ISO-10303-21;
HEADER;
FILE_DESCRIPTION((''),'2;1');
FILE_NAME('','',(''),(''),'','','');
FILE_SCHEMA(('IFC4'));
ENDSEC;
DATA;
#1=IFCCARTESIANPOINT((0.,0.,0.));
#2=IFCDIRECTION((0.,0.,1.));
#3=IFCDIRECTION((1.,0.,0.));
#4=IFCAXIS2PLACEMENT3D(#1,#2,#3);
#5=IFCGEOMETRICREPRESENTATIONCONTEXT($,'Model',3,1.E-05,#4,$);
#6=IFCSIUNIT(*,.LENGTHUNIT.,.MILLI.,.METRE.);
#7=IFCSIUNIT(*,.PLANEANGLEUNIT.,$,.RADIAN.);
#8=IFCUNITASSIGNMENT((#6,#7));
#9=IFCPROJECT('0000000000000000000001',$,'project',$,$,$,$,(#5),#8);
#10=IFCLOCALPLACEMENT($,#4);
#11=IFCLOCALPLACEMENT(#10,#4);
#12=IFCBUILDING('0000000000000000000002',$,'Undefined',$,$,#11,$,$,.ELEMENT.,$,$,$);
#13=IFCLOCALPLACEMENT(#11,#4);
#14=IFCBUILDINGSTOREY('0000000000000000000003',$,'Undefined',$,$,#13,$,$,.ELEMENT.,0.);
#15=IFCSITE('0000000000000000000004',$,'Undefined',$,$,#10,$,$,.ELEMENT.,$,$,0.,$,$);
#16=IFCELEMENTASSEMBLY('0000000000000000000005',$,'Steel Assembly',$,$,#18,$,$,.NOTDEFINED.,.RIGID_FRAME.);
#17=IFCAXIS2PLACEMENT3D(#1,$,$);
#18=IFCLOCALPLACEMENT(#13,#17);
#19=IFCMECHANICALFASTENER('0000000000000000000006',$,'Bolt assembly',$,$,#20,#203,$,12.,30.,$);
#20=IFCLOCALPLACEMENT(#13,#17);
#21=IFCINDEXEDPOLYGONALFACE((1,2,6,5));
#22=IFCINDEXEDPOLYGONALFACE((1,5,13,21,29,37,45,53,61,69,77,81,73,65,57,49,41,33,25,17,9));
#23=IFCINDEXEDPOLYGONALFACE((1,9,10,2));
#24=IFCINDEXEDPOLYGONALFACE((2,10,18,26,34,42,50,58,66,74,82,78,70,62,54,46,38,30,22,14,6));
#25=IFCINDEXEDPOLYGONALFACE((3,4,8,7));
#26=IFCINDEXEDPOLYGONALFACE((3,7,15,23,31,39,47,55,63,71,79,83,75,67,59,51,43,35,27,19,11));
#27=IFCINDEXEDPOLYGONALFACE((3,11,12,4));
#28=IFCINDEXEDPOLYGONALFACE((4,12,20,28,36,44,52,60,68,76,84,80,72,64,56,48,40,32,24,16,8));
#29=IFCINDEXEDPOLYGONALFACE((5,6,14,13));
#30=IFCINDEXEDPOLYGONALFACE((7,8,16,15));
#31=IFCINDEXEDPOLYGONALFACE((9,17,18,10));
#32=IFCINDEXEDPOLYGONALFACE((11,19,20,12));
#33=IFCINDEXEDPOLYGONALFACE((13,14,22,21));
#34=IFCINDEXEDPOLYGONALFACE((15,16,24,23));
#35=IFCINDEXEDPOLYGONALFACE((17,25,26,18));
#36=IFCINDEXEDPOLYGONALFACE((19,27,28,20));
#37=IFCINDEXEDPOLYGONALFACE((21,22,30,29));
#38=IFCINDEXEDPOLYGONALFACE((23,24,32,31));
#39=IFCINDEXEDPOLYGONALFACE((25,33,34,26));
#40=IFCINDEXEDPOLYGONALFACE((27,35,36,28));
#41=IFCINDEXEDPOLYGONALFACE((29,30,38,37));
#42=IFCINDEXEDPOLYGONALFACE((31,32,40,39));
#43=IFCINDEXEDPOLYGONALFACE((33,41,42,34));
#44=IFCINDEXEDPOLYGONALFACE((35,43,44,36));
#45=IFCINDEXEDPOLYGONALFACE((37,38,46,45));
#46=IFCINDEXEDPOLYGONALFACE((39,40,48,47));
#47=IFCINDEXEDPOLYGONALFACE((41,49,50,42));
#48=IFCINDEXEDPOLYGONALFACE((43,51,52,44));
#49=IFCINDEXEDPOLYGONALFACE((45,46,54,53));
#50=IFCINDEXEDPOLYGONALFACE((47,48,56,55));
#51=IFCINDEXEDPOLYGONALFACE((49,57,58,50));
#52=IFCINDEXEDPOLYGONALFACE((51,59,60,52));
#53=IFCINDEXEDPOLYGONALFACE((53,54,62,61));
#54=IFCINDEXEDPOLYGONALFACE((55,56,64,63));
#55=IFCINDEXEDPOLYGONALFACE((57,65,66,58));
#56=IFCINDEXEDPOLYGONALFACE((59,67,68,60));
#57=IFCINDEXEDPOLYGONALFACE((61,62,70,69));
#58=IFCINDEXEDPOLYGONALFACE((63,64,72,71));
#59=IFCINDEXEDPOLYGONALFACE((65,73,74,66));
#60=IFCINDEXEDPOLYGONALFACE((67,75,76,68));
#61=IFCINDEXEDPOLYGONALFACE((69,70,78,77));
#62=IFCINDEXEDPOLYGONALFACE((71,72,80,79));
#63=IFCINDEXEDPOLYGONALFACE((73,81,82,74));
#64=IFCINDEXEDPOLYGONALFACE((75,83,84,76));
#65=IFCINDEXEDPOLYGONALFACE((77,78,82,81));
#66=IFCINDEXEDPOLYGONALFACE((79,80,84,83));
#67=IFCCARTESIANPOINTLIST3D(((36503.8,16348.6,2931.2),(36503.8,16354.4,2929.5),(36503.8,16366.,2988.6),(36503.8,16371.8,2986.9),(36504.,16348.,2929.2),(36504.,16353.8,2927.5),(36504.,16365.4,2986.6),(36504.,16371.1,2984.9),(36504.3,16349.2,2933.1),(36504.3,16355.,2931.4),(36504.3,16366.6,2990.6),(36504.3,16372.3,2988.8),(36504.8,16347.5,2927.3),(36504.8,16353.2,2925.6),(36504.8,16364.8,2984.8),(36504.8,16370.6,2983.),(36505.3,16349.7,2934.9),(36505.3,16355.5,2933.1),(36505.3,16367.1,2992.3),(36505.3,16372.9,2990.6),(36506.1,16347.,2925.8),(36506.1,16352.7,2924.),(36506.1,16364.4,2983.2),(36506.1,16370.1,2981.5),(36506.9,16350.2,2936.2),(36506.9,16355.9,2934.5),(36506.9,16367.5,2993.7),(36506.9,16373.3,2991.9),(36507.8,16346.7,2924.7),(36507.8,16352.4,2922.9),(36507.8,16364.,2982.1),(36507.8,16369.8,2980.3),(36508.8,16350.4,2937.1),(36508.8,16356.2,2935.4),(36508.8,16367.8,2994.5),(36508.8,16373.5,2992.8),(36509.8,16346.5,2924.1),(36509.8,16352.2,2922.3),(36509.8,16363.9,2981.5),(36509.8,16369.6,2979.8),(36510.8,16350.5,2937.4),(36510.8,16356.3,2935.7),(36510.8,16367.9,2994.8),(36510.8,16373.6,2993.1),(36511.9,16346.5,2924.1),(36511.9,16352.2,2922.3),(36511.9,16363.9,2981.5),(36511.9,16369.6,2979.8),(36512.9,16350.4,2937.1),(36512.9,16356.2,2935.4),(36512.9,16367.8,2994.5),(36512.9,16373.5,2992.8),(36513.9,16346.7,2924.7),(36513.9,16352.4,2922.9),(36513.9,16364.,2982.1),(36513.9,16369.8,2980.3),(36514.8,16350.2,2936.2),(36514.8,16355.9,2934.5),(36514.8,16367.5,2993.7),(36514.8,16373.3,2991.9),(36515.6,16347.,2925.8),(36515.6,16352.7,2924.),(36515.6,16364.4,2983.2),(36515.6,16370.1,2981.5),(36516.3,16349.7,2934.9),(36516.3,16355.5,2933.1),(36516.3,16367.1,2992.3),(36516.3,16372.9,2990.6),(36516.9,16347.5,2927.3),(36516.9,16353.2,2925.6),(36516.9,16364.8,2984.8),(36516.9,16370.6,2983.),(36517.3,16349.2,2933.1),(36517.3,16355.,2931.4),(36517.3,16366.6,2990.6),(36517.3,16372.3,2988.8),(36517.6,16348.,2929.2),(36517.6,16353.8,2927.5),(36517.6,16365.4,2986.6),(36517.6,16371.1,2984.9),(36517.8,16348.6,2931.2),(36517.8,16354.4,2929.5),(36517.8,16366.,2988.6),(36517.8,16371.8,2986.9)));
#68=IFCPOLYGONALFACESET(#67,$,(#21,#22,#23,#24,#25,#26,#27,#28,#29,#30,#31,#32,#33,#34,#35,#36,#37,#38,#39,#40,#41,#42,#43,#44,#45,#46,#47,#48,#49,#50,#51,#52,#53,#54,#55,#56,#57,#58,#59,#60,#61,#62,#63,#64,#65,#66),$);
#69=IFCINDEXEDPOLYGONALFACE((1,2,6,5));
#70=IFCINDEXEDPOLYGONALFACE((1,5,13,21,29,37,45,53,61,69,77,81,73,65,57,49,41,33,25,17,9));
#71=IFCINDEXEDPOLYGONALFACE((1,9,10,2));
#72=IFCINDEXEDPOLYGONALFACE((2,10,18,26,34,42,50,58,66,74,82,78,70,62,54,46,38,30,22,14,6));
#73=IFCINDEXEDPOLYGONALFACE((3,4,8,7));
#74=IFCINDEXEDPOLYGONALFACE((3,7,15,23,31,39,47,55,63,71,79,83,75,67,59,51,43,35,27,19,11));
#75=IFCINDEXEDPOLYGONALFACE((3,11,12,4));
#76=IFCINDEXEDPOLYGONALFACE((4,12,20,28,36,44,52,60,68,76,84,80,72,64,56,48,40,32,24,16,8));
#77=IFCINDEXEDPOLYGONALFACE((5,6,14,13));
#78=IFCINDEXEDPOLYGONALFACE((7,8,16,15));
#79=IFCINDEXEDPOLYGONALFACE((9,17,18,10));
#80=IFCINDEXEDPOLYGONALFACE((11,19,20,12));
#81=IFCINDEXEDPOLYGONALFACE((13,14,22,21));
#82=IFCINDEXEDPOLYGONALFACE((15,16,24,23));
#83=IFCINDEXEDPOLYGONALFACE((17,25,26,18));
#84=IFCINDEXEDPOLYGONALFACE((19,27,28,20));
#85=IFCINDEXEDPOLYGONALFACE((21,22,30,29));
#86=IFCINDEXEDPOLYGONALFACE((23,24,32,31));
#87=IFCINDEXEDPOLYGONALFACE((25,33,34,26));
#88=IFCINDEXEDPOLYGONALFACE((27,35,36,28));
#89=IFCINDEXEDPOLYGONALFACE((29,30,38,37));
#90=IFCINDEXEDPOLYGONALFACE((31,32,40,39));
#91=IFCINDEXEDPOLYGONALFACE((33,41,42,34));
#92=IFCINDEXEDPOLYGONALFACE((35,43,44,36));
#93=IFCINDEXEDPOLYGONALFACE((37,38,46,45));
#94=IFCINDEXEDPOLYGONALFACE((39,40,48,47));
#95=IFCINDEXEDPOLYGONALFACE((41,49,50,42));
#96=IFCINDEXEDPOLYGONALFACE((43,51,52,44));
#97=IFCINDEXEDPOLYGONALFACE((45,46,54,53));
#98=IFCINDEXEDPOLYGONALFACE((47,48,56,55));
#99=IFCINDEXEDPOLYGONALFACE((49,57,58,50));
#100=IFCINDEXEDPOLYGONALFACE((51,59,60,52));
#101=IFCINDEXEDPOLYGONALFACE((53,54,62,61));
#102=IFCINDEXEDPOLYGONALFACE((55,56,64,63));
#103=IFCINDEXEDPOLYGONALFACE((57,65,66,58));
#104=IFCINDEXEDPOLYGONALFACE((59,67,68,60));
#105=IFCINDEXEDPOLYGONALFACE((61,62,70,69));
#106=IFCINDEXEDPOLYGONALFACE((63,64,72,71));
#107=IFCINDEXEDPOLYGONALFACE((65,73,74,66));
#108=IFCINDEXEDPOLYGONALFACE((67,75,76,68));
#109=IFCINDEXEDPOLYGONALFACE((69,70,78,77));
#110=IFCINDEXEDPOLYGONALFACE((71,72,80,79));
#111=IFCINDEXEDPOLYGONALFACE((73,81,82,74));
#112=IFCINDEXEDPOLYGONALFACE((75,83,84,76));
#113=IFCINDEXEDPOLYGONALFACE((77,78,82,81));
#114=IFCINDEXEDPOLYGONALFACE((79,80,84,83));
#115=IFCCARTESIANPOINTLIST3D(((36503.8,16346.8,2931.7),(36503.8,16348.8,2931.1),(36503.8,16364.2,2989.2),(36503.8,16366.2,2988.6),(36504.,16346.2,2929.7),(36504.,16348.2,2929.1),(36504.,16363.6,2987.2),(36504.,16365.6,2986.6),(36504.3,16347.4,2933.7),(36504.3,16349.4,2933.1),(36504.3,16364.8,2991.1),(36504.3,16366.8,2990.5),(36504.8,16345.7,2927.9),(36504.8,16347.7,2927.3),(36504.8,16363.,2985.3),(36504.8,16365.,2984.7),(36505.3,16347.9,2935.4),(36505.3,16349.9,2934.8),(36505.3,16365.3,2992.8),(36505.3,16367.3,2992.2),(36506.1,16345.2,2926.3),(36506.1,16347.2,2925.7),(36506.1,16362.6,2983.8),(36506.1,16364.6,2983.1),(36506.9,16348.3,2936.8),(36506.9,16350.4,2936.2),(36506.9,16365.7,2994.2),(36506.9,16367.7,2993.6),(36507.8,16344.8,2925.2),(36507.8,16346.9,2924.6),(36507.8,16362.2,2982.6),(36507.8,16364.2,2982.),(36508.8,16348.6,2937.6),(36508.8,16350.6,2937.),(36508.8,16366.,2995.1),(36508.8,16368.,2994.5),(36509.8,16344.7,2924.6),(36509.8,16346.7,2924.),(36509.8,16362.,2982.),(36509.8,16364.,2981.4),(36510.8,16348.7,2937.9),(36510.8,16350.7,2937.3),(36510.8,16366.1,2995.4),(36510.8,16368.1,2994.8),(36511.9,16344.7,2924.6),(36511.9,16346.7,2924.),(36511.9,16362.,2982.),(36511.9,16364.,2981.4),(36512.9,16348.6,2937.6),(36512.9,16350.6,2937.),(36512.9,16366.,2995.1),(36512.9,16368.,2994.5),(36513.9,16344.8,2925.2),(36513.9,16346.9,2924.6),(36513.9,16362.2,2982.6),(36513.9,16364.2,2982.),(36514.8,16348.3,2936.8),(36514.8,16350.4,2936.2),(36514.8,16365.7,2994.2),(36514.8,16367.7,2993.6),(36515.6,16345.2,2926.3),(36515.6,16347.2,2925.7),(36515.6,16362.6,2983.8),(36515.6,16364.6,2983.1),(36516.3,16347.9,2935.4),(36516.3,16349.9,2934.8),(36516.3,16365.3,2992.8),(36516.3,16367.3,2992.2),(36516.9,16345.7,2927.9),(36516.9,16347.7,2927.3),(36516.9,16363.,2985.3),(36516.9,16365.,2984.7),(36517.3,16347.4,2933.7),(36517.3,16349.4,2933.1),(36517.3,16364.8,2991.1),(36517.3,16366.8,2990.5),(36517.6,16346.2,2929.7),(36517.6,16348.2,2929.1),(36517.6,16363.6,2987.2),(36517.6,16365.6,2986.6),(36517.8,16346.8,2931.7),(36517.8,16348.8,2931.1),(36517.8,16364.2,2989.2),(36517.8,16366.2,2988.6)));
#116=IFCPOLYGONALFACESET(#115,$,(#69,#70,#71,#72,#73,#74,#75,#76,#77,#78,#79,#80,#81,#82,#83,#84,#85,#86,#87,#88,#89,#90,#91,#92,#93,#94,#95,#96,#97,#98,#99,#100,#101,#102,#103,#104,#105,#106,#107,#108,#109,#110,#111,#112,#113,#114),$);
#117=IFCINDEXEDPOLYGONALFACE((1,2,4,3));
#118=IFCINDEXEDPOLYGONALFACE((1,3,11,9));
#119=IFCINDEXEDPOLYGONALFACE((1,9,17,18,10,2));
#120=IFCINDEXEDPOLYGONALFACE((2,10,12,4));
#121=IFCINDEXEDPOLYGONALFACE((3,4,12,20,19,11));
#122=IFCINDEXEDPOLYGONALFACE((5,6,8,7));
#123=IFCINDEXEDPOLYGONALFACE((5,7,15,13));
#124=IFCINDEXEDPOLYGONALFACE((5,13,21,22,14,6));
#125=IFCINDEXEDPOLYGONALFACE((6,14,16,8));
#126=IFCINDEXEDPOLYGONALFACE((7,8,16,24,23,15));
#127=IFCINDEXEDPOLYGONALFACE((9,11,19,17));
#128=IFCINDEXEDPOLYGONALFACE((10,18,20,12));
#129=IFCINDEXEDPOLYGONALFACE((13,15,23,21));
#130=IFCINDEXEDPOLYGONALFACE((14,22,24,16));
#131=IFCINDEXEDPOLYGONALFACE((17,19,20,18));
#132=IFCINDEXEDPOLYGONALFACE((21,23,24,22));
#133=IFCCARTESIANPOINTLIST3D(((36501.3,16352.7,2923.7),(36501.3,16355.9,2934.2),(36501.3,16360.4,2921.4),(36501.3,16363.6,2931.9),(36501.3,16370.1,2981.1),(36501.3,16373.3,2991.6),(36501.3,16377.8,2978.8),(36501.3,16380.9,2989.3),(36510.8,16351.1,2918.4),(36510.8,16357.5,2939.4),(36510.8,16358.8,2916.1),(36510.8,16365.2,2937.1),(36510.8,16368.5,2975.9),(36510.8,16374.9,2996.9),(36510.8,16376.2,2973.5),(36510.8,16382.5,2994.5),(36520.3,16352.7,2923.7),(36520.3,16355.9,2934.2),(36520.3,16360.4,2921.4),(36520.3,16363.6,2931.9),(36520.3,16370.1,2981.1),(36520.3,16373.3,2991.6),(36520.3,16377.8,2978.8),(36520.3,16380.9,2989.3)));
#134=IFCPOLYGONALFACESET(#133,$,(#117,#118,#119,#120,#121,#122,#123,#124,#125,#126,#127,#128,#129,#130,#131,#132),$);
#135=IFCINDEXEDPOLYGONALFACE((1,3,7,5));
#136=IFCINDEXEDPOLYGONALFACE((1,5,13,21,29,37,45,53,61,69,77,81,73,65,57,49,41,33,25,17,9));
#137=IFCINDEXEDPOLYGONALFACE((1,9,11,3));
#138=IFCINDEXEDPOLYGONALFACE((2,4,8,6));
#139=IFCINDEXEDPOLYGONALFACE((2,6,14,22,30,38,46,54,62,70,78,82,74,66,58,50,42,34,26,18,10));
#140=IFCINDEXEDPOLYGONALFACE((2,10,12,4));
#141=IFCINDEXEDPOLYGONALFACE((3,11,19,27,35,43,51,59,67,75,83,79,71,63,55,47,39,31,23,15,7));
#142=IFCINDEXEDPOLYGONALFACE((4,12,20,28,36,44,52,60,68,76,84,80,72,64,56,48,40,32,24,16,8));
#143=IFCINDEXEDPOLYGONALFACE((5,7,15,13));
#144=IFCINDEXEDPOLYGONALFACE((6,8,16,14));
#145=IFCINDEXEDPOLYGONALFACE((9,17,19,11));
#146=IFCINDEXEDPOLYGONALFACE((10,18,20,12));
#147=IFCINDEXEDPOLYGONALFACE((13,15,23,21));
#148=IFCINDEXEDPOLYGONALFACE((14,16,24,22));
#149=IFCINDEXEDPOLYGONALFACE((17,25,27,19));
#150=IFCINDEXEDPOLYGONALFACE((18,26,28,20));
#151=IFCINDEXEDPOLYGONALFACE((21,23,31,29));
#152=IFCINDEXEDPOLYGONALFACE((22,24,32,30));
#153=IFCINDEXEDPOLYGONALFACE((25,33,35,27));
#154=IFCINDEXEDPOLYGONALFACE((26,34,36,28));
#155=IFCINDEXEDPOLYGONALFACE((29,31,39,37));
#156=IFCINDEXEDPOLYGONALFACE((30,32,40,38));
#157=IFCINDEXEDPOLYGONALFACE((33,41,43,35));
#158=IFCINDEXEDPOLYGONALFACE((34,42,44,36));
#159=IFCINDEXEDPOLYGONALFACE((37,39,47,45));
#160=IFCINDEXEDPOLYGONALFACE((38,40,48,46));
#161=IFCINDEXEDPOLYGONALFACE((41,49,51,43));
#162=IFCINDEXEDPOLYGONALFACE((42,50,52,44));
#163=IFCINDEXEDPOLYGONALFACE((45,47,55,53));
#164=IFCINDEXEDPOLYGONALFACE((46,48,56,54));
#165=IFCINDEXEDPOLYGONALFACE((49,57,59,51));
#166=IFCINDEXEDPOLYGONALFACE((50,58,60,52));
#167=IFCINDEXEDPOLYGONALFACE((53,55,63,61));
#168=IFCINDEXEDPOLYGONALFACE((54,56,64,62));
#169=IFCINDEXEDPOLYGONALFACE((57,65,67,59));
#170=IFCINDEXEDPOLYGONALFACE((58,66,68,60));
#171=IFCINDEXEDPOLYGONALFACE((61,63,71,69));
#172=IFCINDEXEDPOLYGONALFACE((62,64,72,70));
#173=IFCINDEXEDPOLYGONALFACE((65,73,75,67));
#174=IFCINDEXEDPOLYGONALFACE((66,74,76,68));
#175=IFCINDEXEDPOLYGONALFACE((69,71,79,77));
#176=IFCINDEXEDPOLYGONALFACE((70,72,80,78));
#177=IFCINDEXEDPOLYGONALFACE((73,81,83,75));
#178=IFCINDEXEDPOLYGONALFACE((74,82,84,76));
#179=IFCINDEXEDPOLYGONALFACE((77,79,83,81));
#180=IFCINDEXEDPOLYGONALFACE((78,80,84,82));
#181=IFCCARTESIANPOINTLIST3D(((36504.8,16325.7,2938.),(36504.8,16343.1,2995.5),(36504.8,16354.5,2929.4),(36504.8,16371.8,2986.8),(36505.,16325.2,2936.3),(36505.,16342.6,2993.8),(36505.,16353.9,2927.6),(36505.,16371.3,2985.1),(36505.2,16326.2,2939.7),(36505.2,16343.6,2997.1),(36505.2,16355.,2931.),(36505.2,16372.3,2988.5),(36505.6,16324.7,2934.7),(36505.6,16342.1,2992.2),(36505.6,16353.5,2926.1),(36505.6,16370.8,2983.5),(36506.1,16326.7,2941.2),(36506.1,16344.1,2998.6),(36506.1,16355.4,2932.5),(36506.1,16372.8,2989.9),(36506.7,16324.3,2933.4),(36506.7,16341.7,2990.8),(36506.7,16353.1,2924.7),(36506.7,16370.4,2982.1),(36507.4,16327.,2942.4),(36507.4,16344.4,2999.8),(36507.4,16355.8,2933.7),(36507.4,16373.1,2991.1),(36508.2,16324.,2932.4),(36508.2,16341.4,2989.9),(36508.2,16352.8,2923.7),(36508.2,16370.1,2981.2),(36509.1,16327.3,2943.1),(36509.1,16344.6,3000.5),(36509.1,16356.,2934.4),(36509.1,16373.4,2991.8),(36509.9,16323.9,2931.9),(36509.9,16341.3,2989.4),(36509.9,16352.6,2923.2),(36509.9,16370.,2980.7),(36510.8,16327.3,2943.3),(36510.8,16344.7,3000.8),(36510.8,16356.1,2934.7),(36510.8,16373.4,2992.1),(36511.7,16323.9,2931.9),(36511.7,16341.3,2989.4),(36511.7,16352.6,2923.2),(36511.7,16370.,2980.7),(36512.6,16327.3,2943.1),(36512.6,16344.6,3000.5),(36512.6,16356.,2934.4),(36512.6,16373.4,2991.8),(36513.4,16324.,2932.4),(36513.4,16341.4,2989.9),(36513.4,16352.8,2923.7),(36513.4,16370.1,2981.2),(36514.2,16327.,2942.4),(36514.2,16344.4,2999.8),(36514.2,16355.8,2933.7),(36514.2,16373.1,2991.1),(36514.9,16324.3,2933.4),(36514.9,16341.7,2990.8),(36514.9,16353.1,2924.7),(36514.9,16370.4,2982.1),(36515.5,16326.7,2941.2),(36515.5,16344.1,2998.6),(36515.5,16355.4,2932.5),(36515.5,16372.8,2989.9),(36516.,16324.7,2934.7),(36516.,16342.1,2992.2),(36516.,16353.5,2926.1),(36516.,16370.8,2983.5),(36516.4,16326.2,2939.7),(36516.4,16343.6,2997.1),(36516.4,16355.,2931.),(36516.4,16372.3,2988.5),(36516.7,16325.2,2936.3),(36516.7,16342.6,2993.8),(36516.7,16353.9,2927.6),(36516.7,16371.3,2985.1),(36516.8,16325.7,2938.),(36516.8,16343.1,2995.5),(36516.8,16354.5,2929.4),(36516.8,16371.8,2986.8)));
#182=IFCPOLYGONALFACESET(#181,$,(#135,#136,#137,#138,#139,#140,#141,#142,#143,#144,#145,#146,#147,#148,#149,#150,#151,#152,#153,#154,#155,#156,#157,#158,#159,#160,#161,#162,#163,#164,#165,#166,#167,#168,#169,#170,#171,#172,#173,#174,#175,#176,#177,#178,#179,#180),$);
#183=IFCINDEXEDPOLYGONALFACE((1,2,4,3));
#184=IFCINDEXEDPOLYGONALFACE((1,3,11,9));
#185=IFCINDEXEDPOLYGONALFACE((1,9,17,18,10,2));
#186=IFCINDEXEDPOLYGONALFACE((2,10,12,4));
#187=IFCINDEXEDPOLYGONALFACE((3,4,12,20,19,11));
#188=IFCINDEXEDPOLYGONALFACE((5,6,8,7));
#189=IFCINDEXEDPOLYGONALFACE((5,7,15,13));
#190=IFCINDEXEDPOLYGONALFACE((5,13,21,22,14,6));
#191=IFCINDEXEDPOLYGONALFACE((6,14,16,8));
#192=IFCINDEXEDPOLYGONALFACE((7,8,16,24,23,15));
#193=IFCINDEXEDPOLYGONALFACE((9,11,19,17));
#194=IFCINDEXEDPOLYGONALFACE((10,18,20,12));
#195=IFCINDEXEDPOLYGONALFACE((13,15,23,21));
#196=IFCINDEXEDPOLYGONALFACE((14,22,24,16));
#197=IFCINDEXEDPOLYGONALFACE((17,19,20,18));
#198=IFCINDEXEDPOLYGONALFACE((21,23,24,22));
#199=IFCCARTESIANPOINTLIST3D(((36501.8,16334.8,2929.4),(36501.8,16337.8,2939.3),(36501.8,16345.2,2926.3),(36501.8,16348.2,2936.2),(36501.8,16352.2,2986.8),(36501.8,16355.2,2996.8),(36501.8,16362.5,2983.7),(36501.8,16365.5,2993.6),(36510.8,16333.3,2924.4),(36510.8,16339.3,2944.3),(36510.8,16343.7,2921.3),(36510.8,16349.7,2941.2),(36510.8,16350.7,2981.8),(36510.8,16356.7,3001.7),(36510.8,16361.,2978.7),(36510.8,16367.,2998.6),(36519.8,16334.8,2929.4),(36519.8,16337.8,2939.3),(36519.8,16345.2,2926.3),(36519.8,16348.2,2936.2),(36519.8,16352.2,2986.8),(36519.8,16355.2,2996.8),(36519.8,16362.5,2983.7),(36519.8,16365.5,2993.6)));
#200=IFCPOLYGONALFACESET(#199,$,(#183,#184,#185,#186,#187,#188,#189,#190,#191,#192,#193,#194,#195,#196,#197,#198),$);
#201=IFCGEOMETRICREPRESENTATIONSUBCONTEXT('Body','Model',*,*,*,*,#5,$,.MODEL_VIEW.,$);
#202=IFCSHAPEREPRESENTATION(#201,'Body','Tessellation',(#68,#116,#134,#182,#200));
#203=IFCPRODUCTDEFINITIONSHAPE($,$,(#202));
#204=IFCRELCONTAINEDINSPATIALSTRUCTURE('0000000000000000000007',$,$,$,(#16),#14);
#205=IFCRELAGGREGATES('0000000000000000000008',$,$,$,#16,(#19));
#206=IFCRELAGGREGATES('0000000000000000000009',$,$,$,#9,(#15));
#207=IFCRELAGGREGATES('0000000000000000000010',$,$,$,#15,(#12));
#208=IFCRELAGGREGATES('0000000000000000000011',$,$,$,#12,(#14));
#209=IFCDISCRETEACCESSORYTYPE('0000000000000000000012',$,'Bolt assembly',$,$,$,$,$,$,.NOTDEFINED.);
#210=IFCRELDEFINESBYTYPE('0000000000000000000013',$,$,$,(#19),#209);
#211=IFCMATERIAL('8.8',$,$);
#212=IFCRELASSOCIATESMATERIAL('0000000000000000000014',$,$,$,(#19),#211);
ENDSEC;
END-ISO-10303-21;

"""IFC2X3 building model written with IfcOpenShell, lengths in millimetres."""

from ifc_helpers import new_model, si_unit, frame, origin_with_axes, origin_2d_with_axis, place, context, subcontext, project, spatial, polyline, circle, outline, extrude, source, transform, mapped, material, type_object, element, aggregate, save


model = new_model("IFC2X3")

# Units and contexts
model_context = context("Model", 3, precision=1e-05, world=origin_with_axes())
body_context = subcontext(model_context, "Body", "Model", "MODEL_VIEW")
ifc_project = project(units=[si_unit("LENGTHUNIT", "METRE", prefix="MILLI"), si_unit("PLANEANGLEUNIT", "RADIAN")], contexts=[model_context])

# Site, building, storey
site_placement = place(None, origin_with_axes())
site = spatial("IfcSite", under=ifc_project, at=site_placement, Name="Undefined", CompositionType="ELEMENT", RefElevation=0.0)
building_placement = place(site_placement, origin_with_axes())
building = spatial("IfcBuilding", under=site, at=building_placement, Name="Undefined", CompositionType="ELEMENT")
storey_placement = place(building_placement, origin_with_axes())
storey = spatial("IfcBuildingStorey", under=building, at=storey_placement, Name="Undefined", CompositionType="ELEMENT", Elevation=0.0)

# Shared definitions
discrete_accessory_type_1 = type_object("IfcDiscreteAccessoryType", Name="Bolt assembly")

# Element assembly, mechanical fastener
assembly_1_placement = place(storey_placement, origin_with_axes())
assembly_1 = element("IfcElementAssembly", 1, at=assembly_1_placement, inside=storey, Name="Steel Assembly", AssemblyPlace="NOTDEFINED", PredefinedType="RIGID_FRAME")
ifc_material_1 = material(Name="8.8")
shared_shape_1 = source(origin_with_axes(), body_context, "Body", "SweptSolid", [
    extrude(circle(Radius=7.0, at=origin_2d_with_axis()), frame((0.0, -2.9, 0.0), z_axis=(0.0, 1.0, 0.0), x_axis=(1.0, 0.0, 0.0)), (0.0, 0.0, 1.0), 6.0),
    extrude(circle(Radius=7.0, at=origin_2d_with_axis()), frame((0.0, 2.9, 0.0), z_axis=(0.0, 1.0, 0.0), x_axis=(1.0, 0.0, 0.0)), (0.0, 0.0, 1.0), 2.1),
    extrude(outline(polyline([(11.0, 0.0), (5.5, 9.5), (-5.5, 9.5), (-11.0, 0.0), (-5.5, -9.5), (5.5, -9.5), (11.0, 0.0)])), frame((0.0, -11.0, 0.0), z_axis=(0.0, 1.0, 0.0), x_axis=(1.0, 0.0, 0.0)), (0.0, 0.0, 1.0), 8.0),
    extrude(circle(Radius=6.0, at=origin_2d_with_axis()), frame((0.0, -3.0, 0.0), z_axis=(0.0, 1.0, 0.0), x_axis=(1.0, 0.0, 0.0)), (0.0, 0.0, 1.0), 30.0),
    extrude(outline(polyline([(10.4, 0.0), (5.2, 9.0), (-5.2, 9.0), (-10.4, 0.0), (-5.2, -9.0), (5.2, -9.0), (10.4, 0.0)])), frame((0.0, 5.0, 0.0), z_axis=(0.0, 1.0, 0.0), x_axis=(1.0, 0.0, 0.0)), (0.0, 0.0, 1.0), 10.8),
])
mechanical_fastener_1_placement = place(assembly_1_placement, frame((36465.8, 16338.4, 2886.7), z_axis=(1.0, 0.0, 0.0), x_axis=(0.0, 0.289497, 0.957179)))
mechanical_fastener_1 = element("IfcMechanicalFastener", 2, at=mechanical_fastener_1_placement, type_object=discrete_accessory_type_1, material=ifc_material_1, Name="Bolt assembly", NominalDiameter=12.0, NominalLength=30.0, context=body_context, shape_type="MappedRepresentation", body=[
    mapped(shared_shape_1, transform((45.0, 0.0, 45.0))),
    mapped(shared_shape_1, transform((105.0, 0.0, 45.0))),
])
aggregate(assembly_1, [mechanical_fastener_1])

save(model, "model.ifc")
